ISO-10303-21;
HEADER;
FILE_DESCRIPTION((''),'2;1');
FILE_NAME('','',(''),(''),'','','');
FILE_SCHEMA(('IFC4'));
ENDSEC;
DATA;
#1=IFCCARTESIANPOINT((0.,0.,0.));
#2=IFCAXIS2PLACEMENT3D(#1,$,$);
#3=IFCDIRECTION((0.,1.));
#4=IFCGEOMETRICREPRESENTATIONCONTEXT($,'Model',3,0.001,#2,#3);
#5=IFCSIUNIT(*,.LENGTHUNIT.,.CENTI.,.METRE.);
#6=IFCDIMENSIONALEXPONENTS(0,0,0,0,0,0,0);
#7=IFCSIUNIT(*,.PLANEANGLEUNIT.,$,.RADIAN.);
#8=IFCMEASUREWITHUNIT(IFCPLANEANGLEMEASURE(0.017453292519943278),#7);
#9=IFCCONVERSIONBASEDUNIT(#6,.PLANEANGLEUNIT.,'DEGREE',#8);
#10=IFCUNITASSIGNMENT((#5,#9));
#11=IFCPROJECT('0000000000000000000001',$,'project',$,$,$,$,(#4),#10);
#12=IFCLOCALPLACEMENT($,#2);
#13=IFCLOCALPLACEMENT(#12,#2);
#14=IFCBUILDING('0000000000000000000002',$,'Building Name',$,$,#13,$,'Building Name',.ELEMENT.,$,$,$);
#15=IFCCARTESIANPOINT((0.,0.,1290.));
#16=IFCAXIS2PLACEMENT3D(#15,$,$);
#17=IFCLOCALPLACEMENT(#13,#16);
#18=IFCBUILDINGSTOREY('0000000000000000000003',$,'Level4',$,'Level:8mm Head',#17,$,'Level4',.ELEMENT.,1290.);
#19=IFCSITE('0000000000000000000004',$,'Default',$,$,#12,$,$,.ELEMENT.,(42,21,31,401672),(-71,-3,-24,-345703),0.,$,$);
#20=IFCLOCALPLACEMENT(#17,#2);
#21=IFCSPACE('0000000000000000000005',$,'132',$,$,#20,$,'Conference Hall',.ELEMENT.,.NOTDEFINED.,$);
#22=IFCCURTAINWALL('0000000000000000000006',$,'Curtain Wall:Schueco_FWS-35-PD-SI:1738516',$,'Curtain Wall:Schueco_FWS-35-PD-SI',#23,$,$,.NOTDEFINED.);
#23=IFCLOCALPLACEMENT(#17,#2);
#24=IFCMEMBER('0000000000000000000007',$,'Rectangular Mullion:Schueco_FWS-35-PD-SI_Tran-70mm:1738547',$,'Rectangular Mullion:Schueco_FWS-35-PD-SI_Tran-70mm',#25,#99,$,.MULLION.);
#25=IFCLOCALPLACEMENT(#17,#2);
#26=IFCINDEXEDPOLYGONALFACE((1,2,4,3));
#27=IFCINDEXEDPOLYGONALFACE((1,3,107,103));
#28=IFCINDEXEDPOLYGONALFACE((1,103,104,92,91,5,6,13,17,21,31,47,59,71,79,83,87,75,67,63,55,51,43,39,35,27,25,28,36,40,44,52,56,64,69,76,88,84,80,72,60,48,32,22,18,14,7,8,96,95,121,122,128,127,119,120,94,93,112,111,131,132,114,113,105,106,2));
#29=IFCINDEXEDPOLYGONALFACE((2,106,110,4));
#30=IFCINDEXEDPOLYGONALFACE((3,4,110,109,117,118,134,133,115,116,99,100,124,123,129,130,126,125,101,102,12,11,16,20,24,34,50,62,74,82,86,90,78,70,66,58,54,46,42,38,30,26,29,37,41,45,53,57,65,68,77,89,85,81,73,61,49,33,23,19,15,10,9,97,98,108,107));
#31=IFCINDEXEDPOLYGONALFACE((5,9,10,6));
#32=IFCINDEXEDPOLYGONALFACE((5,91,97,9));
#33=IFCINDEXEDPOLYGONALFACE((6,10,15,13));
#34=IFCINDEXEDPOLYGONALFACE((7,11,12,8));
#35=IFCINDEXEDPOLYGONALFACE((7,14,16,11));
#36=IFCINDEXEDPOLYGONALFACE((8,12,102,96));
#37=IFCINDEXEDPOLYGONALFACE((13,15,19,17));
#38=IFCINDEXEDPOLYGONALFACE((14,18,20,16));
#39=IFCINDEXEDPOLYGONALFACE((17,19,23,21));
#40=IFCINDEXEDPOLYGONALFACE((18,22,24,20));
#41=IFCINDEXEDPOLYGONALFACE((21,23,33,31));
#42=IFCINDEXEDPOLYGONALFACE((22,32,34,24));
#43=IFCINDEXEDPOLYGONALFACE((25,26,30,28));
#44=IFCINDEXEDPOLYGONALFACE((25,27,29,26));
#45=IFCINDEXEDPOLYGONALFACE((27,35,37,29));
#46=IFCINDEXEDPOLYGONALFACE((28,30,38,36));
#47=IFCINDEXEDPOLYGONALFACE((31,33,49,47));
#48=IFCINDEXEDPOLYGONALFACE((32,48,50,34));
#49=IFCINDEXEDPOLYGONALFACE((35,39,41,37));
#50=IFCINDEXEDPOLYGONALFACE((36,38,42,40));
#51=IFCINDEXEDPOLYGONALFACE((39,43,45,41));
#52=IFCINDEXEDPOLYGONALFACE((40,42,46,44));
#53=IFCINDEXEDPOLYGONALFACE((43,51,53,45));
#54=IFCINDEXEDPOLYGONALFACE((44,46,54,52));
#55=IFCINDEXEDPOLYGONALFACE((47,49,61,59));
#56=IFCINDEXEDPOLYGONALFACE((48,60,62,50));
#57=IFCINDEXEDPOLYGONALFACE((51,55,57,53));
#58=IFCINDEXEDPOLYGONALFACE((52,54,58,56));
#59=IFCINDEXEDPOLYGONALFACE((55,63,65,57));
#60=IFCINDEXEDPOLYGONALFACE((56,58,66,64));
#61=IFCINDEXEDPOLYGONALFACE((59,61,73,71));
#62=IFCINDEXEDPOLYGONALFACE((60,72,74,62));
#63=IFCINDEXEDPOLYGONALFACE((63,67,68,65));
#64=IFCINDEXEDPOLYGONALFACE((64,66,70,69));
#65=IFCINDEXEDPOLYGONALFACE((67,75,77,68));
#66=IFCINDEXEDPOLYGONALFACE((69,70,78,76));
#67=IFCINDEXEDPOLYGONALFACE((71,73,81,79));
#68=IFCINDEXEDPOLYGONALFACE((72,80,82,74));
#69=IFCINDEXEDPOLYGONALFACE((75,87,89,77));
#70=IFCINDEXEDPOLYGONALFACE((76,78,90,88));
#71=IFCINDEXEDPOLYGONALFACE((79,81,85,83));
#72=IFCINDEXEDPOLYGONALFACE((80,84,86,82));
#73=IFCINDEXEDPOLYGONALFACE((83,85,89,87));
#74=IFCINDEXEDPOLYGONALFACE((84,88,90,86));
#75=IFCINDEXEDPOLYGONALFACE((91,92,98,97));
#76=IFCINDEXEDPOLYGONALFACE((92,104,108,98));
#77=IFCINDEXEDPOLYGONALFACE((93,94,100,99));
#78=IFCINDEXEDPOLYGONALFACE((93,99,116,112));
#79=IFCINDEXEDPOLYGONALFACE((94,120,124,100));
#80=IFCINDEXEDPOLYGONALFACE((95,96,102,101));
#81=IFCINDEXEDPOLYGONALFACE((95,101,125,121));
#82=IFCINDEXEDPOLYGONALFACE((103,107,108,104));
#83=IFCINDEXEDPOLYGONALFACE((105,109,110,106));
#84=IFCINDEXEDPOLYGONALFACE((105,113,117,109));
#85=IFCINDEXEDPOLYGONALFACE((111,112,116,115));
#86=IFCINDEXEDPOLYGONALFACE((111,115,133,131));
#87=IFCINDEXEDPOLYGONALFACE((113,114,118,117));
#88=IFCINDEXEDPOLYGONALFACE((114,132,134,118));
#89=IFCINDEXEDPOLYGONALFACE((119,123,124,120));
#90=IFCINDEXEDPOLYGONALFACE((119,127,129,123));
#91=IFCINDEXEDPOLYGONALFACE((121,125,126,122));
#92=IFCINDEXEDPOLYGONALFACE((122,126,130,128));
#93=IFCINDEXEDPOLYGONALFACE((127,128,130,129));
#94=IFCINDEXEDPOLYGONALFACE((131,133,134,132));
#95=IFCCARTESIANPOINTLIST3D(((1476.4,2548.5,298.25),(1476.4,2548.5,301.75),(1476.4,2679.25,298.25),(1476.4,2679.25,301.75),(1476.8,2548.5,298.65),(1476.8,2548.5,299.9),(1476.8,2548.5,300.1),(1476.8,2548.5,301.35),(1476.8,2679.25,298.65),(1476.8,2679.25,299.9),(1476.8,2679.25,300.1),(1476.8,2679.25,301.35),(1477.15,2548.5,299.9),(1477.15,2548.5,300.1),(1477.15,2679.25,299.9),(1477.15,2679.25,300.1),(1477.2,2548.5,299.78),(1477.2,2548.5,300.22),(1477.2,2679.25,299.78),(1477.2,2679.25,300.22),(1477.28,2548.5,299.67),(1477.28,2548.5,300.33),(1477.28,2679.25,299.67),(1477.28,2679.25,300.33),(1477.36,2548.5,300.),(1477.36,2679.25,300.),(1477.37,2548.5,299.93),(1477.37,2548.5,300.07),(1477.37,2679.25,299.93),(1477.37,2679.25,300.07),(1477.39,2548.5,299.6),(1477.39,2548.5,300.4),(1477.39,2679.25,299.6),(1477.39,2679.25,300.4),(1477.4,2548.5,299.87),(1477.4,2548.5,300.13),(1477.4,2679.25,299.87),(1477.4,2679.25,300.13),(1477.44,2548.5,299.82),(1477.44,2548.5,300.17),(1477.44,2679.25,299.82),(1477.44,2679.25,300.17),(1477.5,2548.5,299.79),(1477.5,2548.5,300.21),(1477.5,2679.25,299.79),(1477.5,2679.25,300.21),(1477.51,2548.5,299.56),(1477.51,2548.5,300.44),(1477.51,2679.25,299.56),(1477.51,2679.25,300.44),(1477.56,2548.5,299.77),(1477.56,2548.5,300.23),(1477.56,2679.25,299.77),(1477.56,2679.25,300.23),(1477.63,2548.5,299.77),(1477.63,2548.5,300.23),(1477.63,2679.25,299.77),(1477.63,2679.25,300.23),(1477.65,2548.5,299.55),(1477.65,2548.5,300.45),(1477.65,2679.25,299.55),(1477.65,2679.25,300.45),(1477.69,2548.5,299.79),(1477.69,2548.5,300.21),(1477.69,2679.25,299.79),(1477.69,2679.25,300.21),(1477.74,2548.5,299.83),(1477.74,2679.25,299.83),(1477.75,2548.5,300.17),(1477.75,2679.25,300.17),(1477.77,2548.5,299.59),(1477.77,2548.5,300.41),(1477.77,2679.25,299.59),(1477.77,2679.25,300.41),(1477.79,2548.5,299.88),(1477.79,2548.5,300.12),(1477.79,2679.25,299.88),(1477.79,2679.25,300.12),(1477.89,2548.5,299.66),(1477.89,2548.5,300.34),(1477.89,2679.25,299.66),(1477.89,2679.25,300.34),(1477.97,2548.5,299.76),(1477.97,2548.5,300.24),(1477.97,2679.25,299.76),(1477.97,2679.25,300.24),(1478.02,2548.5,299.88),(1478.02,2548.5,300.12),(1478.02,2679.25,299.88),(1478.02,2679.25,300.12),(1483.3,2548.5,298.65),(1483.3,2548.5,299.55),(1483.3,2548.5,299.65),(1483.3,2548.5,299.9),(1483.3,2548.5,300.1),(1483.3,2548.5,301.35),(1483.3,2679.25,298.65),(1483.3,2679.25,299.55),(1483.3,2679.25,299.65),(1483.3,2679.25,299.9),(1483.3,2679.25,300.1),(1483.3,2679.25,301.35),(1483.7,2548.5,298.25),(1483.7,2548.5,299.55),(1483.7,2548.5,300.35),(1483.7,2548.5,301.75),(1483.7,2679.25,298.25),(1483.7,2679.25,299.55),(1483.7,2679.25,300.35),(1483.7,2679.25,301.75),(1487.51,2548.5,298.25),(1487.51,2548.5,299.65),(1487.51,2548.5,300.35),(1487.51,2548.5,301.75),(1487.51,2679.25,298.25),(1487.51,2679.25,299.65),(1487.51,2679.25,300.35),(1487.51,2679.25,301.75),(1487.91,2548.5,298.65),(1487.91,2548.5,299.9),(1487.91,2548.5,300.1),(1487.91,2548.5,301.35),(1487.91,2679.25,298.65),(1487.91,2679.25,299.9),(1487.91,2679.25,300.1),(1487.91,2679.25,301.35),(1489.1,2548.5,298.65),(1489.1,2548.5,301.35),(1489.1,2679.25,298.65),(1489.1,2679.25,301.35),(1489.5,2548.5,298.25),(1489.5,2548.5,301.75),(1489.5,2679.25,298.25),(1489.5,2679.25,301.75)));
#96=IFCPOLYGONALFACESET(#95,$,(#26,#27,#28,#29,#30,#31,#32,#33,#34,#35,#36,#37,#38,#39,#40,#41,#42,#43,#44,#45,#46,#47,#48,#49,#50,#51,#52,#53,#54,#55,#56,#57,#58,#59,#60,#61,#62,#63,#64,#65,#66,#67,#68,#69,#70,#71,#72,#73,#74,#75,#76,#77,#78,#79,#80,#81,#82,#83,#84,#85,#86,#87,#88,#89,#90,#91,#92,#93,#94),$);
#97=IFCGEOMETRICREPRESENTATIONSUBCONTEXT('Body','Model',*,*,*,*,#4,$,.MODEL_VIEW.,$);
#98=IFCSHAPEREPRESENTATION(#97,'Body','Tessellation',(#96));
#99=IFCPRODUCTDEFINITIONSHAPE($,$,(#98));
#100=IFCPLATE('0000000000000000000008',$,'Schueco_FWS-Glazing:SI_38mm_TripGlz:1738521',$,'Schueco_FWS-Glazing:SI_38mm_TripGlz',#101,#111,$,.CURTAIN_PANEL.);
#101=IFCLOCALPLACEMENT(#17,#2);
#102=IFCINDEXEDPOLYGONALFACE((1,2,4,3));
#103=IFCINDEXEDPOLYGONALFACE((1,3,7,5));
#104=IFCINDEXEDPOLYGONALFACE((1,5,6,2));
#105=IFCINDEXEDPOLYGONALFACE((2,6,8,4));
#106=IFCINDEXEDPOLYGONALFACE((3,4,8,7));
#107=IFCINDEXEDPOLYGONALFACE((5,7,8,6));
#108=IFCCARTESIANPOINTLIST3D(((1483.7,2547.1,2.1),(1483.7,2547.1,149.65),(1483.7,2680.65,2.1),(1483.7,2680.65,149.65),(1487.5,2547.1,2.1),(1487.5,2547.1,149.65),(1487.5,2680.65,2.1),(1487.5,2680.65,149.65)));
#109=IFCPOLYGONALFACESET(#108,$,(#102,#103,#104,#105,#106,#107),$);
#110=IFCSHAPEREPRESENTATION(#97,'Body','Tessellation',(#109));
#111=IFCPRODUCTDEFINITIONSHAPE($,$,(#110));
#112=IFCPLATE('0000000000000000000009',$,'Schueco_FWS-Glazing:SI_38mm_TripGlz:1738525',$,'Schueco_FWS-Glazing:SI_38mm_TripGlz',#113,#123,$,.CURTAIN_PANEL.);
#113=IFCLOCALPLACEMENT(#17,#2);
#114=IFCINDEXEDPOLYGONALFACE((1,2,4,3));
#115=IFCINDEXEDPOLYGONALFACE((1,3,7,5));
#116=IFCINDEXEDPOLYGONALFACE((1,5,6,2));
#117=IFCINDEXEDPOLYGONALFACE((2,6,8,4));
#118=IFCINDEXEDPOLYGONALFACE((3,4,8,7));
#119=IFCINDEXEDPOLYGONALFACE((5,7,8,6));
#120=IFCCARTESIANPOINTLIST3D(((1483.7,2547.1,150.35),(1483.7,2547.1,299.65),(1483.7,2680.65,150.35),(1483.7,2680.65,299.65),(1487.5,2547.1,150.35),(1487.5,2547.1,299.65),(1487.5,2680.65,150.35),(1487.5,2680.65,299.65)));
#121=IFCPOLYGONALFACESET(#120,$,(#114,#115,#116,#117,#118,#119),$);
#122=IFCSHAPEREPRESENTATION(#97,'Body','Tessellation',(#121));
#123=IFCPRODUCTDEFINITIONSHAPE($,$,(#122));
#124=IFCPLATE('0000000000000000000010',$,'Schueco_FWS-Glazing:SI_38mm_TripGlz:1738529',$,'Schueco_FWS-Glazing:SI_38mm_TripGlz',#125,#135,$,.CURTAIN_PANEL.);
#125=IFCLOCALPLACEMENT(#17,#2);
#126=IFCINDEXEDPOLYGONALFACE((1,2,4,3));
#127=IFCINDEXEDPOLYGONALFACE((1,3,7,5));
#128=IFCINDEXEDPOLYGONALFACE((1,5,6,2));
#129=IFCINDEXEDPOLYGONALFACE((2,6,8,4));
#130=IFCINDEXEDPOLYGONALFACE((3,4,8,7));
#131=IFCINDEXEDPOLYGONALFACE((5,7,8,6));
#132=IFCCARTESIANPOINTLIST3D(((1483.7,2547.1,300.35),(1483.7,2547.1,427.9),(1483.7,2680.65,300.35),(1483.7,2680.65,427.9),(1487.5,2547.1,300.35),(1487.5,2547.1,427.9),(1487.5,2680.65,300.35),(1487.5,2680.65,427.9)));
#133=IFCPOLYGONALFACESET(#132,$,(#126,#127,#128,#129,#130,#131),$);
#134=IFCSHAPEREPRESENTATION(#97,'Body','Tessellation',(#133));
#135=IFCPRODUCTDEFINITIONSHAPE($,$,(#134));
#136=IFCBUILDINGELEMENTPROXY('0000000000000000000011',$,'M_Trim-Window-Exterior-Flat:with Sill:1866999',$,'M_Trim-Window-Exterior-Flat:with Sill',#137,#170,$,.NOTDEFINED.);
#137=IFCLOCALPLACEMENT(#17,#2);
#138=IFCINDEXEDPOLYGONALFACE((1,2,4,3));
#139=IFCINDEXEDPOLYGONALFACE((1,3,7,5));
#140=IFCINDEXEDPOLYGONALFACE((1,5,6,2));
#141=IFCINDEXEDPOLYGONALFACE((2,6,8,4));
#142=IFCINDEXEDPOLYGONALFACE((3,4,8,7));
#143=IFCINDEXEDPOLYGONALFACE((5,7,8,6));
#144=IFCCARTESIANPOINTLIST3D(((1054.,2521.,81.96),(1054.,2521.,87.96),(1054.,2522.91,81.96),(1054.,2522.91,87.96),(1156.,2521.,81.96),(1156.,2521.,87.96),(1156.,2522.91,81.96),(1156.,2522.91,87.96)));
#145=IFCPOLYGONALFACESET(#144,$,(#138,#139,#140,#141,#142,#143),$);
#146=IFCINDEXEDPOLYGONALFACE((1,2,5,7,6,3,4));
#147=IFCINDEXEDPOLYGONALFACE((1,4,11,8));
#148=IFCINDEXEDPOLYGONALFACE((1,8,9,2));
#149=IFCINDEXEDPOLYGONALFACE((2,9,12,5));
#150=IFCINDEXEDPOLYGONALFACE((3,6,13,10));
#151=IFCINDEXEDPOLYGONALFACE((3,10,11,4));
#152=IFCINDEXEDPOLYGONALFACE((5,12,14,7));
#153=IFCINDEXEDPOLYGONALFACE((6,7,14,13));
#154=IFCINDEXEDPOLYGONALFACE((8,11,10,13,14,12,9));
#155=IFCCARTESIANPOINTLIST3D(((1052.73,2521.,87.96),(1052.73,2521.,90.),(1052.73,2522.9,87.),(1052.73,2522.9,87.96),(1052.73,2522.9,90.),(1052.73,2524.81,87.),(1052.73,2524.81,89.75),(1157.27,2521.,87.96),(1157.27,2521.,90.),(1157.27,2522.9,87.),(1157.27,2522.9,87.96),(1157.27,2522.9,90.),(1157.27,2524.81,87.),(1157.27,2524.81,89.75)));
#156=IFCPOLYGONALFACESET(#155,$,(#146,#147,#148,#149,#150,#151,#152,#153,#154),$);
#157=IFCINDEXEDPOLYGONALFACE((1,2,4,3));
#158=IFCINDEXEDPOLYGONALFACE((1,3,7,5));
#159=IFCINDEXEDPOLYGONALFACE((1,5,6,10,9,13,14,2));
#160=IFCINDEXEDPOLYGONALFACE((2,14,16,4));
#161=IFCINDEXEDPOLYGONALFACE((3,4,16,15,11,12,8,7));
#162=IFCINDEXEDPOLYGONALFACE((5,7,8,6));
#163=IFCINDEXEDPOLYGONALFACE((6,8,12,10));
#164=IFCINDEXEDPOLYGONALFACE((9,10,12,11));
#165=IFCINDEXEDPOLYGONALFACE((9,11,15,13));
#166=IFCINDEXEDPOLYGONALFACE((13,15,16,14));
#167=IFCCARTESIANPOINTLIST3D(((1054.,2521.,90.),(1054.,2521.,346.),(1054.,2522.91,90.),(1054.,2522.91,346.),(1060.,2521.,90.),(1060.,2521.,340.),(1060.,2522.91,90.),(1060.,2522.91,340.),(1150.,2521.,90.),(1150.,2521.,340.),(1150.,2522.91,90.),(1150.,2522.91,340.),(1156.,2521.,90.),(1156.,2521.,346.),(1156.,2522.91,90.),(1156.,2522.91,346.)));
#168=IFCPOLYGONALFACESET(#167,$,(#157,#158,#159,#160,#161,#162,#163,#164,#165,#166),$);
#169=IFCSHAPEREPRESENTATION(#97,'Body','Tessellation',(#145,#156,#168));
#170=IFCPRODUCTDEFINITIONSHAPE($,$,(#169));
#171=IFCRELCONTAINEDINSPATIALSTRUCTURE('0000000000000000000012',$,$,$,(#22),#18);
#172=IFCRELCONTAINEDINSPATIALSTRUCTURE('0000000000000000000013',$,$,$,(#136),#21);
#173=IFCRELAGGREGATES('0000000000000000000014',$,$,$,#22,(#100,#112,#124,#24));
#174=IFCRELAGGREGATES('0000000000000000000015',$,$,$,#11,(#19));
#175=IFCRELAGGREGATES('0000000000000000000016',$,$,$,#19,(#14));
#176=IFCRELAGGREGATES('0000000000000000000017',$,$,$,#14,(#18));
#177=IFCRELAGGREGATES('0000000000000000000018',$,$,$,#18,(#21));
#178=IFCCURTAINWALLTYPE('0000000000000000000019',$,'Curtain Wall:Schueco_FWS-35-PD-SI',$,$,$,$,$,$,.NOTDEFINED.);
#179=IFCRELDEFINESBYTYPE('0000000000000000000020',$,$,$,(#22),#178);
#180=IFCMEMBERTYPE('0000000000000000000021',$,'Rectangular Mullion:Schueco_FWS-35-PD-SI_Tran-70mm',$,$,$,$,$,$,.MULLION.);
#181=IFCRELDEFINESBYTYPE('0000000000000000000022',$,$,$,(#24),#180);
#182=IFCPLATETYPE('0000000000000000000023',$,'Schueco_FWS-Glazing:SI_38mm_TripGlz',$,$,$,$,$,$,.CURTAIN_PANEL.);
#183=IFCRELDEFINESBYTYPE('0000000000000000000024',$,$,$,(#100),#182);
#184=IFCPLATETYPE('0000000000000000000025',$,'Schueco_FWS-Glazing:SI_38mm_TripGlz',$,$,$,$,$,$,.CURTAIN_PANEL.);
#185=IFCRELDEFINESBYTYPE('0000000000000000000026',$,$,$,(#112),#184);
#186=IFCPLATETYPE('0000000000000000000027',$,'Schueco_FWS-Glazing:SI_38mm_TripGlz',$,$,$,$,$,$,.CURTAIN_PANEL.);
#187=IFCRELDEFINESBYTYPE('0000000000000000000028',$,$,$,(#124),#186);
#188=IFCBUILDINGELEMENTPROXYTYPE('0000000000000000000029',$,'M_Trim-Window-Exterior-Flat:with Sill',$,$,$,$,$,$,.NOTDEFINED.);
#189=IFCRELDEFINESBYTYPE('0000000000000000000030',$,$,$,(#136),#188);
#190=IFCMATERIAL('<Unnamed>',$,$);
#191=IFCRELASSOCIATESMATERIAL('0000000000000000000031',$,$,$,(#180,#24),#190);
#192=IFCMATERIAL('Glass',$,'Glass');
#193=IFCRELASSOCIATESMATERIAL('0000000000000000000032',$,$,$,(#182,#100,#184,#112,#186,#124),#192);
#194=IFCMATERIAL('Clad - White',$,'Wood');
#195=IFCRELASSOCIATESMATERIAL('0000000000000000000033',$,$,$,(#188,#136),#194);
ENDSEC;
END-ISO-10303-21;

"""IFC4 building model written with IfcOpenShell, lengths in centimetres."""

from ifc_helpers import new_model, entity, si_unit, converted_unit, direction, frame, origin, place, context, subcontext, project, spatial, line, arc, indexed_curve, outline, extrude, source, transform, mapped, material, type_object, type_shapes, element, aggregate, save


model = new_model("IFC4")

# Units and contexts
model_context = context("Model", 3, precision=0.001, world=origin(), true_north=direction((0.0, 1.0)))
body_context = subcontext(model_context, "Body", "Model", "MODEL_VIEW")
ifc_project = project(units=[si_unit("LENGTHUNIT", "METRE", prefix="CENTI"), converted_unit("PLANEANGLEUNIT", "DEGREE", entity("IfcPlaneAngleMeasure", 0.017453292519943278), si_unit("PLANEANGLEUNIT", "RADIAN"), dimensions=[0, 0, 0, 0, 0, 0, 0])], contexts=[model_context])

# Site, building, storey
site_placement = place(None, origin())
site = spatial("IfcSite", under=ifc_project, at=site_placement, Name="Default", CompositionType="ELEMENT", RefLatitude=(42, 21, 31, 401672), RefLongitude=(-71, -3, -24, -345703), RefElevation=0.0)
building_placement = place(site_placement, origin())
building = spatial("IfcBuilding", under=site, at=building_placement, Name="Building Name", LongName="Building Name", CompositionType="ELEMENT")
storey_placement = place(building_placement, frame((0.0, 0.0, 1290.0)))
storey = spatial("IfcBuildingStorey", under=building, at=storey_placement, Name="Level4", ObjectType="Level:8mm Head", LongName="Level4", CompositionType="ELEMENT", Elevation=1290.0)

# Curtain wall, member, plates
curtain_wall_type = type_object("IfcCurtainWallType", Name="Curtain Wall:Schueco_FWS-35-PD-SI", PredefinedType="NOTDEFINED")
curtain_wall_placement = place(storey_placement, frame((0.0, 0.0, -1290.0)))
curtain_wall = element("IfcCurtainWall", 1, at=curtain_wall_placement, inside=storey, type_object=curtain_wall_type, Name="Curtain Wall:Schueco_FWS-35-PD-SI:1738516", ObjectType="Curtain Wall:Schueco_FWS-35-PD-SI", PredefinedType="NOTDEFINED")
ifc_material_1 = material(Name="<Unnamed>")
member_type_1 = type_object("IfcMemberType", Name="Rectangular Mullion:Schueco_FWS-35-PD-SI_Tran-70mm", PredefinedType="MULLION", material=ifc_material_1)
shared_shape_1 = source(origin(), body_context, "Body", "SweptSolid", [
    extrude(outline(indexed_curve([(-1.78, -6.52), (1.72, -6.52), (1.72, 0.78), (0.42, 0.78), (0.42, 0.38), (1.32, 0.38), (1.32, -6.12), (0.07, -6.12), (0.07, -5.77), (0.42, -5.34), (0.09, -4.9), (0.09, -5.14), (-0.03, -5.56), (-0.15, -5.14), (-0.15, -4.9), (-0.48, -5.34), (-0.13, -5.77), (-0.13, -6.12), (-1.38, -6.12), (-1.38, 0.38), (-0.13, 0.38), (-0.13, 4.99), (-1.38, 4.99), (-1.38, 6.18), (1.32, 6.18), (1.32, 4.99), (0.07, 4.99), (0.07, 0.38), (0.32, 0.38), (0.32, 4.59), (1.72, 4.59), (1.72, 6.58), (-1.78, 6.58), (-1.78, 4.59), (-0.38, 4.59), (-0.38, 0.78), (-1.78, 0.78)], segments=[line(1, 2, 3, 4, 5, 6, 7, 8, 9), arc(9, 10, 11), line(11, 12), arc(12, 13, 14), line(14, 15), arc(15, 16, 17), line(17, 18, 19, 20, 21, 22, 23, 24, 25, 26, 27, 28, 29, 30, 31, 32, 33, 34, 35, 36, 37, 1)], self_intersect=False)), frame((-0.03, 4.58, -130.75), z_axis=(0.0, 0.0, 1.0), x_axis=(-1.0, 0.0, 0.0)), (0.0, 0.0, 1.0), 130.75),
])
type_shapes(member_type_1, [shared_shape_1])
member_1_placement = place(curtain_wall_placement, frame((1487.5, 2548.5, 1590.0), z_axis=(0.0, -1.0, 0.0), x_axis=(0.0, 0.0, 1.0)))
member_1 = element("IfcMember", 2, at=member_1_placement, type_object=member_type_1, material=ifc_material_1, Name="Rectangular Mullion:Schueco_FWS-35-PD-SI_Tran-70mm:1738547", ObjectType="Rectangular Mullion:Schueco_FWS-35-PD-SI_Tran-70mm", PredefinedType="MULLION", context=body_context, shape_type="MappedRepresentation", body=[
    mapped(shared_shape_1, transform((0.0, 0.0, 0.0), scale=1.0)),
])
ifc_material_2 = material(Name="Glass", Category="Glass")
plate_type_1 = type_object("IfcPlateType", Name="Schueco_FWS-Glazing:SI_38mm_TripGlz", PredefinedType="CURTAIN_PANEL", material=ifc_material_2)
shared_shape_2 = source(origin(), body_context, "Body", "SweptSolid", [
    extrude(outline(indexed_curve([(-1.9, -66.78), (1.9, -66.78), (1.9, 66.78), (-1.9, 66.78), (-1.9, -66.78)], self_intersect=False)), frame((0.0, -1.9, 0.0), z_axis=(0.0, 0.0, 1.0), x_axis=(0.0, 1.0, 0.0)), (0.0, 0.0, 1.0), 147.55),
])
type_shapes(plate_type_1, [shared_shape_2])
plate_1_placement = place(curtain_wall_placement, frame((1487.5, 2613.87, 1292.1), z_axis=(0.0, 0.0, 1.0), x_axis=(0.0, -1.0, 0.0)))
plate_1 = element("IfcPlate", 3, at=plate_1_placement, type_object=plate_type_1, material=ifc_material_2, Name="Schueco_FWS-Glazing:SI_38mm_TripGlz:1738521", ObjectType="Schueco_FWS-Glazing:SI_38mm_TripGlz", PredefinedType="CURTAIN_PANEL", context=body_context, shape_type="MappedRepresentation", body=[
    mapped(shared_shape_2, transform((0.0, 0.0, 0.0), scale=1.0)),
])
plate_type_2 = type_object("IfcPlateType", Name="Schueco_FWS-Glazing:SI_38mm_TripGlz", PredefinedType="CURTAIN_PANEL", material=ifc_material_2)
shared_shape_3 = source(origin(), body_context, "Body", "SweptSolid", [
    extrude(outline(indexed_curve([(-1.9, -66.78), (1.9, -66.78), (1.9, 66.78), (-1.9, 66.78), (-1.9, -66.78)], self_intersect=False)), frame((0.0, -1.9, 0.0), z_axis=(0.0, 0.0, 1.0), x_axis=(0.0, 1.0, 0.0)), (0.0, 0.0, 1.0), 149.3),
])
type_shapes(plate_type_2, [shared_shape_3])
plate_2_placement = place(curtain_wall_placement, frame((1487.5, 2613.87, 1440.35), z_axis=(0.0, 0.0, 1.0), x_axis=(0.0, -1.0, 0.0)))
plate_2 = element("IfcPlate", 4, at=plate_2_placement, type_object=plate_type_2, material=ifc_material_2, Name="Schueco_FWS-Glazing:SI_38mm_TripGlz:1738525", ObjectType="Schueco_FWS-Glazing:SI_38mm_TripGlz", PredefinedType="CURTAIN_PANEL", context=body_context, shape_type="MappedRepresentation", body=[
    mapped(shared_shape_3, transform((0.0, 0.0, 0.0), scale=1.0)),
])
plate_type_3 = type_object("IfcPlateType", Name="Schueco_FWS-Glazing:SI_38mm_TripGlz", PredefinedType="CURTAIN_PANEL", material=ifc_material_2)
shared_shape_4 = source(origin(), body_context, "Body", "SweptSolid", [
    extrude(outline(indexed_curve([(-1.9, -66.77), (1.9, -66.77), (1.9, 66.77), (-1.9, 66.77), (-1.9, -66.77)], self_intersect=False)), frame((0.0, -1.9, 0.0), z_axis=(0.0, 0.0, 1.0), x_axis=(0.0, 1.0, 0.0)), (0.0, 0.0, 1.0), 127.55),
])
type_shapes(plate_type_3, [shared_shape_4])
plate_3_placement = place(curtain_wall_placement, frame((1487.5, 2613.87, 1590.35), z_axis=(0.0, 0.0, 1.0), x_axis=(0.0, -1.0, 0.0)))
plate_3 = element("IfcPlate", 5, at=plate_3_placement, type_object=plate_type_3, material=ifc_material_2, Name="Schueco_FWS-Glazing:SI_38mm_TripGlz:1738529", ObjectType="Schueco_FWS-Glazing:SI_38mm_TripGlz", PredefinedType="CURTAIN_PANEL", context=body_context, shape_type="MappedRepresentation", body=[
    mapped(shared_shape_4, transform((0.0, 0.0, 0.0), scale=1.0)),
])
aggregate(curtain_wall, [plate_1, plate_2, plate_3, member_1])

# Shared definitions
space_placement = place(storey_placement, origin())
space = spatial("IfcSpace", under=storey, at=space_placement, Name="132", LongName="Conference Hall", CompositionType="ELEMENT", PredefinedType="NOTDEFINED")

# Building element proxy
ifc_material_3 = material(Name="Clad - White", Category="Wood")
building_element_proxy_type_1 = type_object("IfcBuildingElementProxyType", Name="M_Trim-Window-Exterior-Flat:with Sill", PredefinedType="NOTDEFINED", material=ifc_material_3)
shared_shape_5 = source(origin(), body_context, "Body", "SweptSolid", [
    extrude(outline(indexed_curve([(-51.0, -3.0), (51.0, -3.0), (51.0, 3.0), (-51.0, 3.0), (-51.0, -3.0)], self_intersect=False)), frame((0.0, -255.04, 0.0), z_axis=(0.0, 0.0, 1.0), x_axis=(-1.0, 0.0, 0.0)), (0.0, 0.0, 1.0), 1.9),
    extrude(outline(indexed_curve([(-1.9, -1.52), (0.0, -1.52), (0.0, -0.57), (1.9, -0.57), (1.9, 1.48), (0.0, 1.48), (-1.9, 1.23), (-1.9, -1.52)], self_intersect=False)), frame((-52.27, -251.48, 1.9), z_axis=(1.0, 0.0, 0.0), x_axis=(0.0, 0.0, -1.0)), (0.0, 0.0, 1.0), 104.54),
    extrude(outline(indexed_curve([(-129.5, -51.0), (126.5, -51.0), (126.5, -45.0), (-123.5, -45.0), (-123.5, 45.0), (126.5, 45.0), (126.5, 51.0), (-129.5, 51.0), (-129.5, -51.0)], self_intersect=False)), frame((0.0, -123.5, 0.0), z_axis=(0.0, 0.0, 1.0), x_axis=(0.0, -1.0, 0.0)), (0.0, 0.0, 1.0), 1.9),
])
type_shapes(building_element_proxy_type_1, [shared_shape_5])
for number, where, z_axis, x_axis, name in (
    (6, (1105.0, 2521.0, 340.0), (0.0, 1.0, 0.0), (-1.0, 0.0, 0.0), "M_Trim-Window-Exterior-Flat:with Sill:1866999"),
):
    element("IfcBuildingElementProxy", number, at=place(space_placement, frame(where, z_axis=z_axis, x_axis=x_axis)), inside=space, type_object=building_element_proxy_type_1, material=ifc_material_3, Name=name, ObjectType="M_Trim-Window-Exterior-Flat:with Sill", PredefinedType="NOTDEFINED", context=body_context, shape_type="MappedRepresentation", body=[
        mapped(shared_shape_5, transform((0.0, 0.0, 0.0), scale=1.0)),
    ])

save(model, "model.ifc")
